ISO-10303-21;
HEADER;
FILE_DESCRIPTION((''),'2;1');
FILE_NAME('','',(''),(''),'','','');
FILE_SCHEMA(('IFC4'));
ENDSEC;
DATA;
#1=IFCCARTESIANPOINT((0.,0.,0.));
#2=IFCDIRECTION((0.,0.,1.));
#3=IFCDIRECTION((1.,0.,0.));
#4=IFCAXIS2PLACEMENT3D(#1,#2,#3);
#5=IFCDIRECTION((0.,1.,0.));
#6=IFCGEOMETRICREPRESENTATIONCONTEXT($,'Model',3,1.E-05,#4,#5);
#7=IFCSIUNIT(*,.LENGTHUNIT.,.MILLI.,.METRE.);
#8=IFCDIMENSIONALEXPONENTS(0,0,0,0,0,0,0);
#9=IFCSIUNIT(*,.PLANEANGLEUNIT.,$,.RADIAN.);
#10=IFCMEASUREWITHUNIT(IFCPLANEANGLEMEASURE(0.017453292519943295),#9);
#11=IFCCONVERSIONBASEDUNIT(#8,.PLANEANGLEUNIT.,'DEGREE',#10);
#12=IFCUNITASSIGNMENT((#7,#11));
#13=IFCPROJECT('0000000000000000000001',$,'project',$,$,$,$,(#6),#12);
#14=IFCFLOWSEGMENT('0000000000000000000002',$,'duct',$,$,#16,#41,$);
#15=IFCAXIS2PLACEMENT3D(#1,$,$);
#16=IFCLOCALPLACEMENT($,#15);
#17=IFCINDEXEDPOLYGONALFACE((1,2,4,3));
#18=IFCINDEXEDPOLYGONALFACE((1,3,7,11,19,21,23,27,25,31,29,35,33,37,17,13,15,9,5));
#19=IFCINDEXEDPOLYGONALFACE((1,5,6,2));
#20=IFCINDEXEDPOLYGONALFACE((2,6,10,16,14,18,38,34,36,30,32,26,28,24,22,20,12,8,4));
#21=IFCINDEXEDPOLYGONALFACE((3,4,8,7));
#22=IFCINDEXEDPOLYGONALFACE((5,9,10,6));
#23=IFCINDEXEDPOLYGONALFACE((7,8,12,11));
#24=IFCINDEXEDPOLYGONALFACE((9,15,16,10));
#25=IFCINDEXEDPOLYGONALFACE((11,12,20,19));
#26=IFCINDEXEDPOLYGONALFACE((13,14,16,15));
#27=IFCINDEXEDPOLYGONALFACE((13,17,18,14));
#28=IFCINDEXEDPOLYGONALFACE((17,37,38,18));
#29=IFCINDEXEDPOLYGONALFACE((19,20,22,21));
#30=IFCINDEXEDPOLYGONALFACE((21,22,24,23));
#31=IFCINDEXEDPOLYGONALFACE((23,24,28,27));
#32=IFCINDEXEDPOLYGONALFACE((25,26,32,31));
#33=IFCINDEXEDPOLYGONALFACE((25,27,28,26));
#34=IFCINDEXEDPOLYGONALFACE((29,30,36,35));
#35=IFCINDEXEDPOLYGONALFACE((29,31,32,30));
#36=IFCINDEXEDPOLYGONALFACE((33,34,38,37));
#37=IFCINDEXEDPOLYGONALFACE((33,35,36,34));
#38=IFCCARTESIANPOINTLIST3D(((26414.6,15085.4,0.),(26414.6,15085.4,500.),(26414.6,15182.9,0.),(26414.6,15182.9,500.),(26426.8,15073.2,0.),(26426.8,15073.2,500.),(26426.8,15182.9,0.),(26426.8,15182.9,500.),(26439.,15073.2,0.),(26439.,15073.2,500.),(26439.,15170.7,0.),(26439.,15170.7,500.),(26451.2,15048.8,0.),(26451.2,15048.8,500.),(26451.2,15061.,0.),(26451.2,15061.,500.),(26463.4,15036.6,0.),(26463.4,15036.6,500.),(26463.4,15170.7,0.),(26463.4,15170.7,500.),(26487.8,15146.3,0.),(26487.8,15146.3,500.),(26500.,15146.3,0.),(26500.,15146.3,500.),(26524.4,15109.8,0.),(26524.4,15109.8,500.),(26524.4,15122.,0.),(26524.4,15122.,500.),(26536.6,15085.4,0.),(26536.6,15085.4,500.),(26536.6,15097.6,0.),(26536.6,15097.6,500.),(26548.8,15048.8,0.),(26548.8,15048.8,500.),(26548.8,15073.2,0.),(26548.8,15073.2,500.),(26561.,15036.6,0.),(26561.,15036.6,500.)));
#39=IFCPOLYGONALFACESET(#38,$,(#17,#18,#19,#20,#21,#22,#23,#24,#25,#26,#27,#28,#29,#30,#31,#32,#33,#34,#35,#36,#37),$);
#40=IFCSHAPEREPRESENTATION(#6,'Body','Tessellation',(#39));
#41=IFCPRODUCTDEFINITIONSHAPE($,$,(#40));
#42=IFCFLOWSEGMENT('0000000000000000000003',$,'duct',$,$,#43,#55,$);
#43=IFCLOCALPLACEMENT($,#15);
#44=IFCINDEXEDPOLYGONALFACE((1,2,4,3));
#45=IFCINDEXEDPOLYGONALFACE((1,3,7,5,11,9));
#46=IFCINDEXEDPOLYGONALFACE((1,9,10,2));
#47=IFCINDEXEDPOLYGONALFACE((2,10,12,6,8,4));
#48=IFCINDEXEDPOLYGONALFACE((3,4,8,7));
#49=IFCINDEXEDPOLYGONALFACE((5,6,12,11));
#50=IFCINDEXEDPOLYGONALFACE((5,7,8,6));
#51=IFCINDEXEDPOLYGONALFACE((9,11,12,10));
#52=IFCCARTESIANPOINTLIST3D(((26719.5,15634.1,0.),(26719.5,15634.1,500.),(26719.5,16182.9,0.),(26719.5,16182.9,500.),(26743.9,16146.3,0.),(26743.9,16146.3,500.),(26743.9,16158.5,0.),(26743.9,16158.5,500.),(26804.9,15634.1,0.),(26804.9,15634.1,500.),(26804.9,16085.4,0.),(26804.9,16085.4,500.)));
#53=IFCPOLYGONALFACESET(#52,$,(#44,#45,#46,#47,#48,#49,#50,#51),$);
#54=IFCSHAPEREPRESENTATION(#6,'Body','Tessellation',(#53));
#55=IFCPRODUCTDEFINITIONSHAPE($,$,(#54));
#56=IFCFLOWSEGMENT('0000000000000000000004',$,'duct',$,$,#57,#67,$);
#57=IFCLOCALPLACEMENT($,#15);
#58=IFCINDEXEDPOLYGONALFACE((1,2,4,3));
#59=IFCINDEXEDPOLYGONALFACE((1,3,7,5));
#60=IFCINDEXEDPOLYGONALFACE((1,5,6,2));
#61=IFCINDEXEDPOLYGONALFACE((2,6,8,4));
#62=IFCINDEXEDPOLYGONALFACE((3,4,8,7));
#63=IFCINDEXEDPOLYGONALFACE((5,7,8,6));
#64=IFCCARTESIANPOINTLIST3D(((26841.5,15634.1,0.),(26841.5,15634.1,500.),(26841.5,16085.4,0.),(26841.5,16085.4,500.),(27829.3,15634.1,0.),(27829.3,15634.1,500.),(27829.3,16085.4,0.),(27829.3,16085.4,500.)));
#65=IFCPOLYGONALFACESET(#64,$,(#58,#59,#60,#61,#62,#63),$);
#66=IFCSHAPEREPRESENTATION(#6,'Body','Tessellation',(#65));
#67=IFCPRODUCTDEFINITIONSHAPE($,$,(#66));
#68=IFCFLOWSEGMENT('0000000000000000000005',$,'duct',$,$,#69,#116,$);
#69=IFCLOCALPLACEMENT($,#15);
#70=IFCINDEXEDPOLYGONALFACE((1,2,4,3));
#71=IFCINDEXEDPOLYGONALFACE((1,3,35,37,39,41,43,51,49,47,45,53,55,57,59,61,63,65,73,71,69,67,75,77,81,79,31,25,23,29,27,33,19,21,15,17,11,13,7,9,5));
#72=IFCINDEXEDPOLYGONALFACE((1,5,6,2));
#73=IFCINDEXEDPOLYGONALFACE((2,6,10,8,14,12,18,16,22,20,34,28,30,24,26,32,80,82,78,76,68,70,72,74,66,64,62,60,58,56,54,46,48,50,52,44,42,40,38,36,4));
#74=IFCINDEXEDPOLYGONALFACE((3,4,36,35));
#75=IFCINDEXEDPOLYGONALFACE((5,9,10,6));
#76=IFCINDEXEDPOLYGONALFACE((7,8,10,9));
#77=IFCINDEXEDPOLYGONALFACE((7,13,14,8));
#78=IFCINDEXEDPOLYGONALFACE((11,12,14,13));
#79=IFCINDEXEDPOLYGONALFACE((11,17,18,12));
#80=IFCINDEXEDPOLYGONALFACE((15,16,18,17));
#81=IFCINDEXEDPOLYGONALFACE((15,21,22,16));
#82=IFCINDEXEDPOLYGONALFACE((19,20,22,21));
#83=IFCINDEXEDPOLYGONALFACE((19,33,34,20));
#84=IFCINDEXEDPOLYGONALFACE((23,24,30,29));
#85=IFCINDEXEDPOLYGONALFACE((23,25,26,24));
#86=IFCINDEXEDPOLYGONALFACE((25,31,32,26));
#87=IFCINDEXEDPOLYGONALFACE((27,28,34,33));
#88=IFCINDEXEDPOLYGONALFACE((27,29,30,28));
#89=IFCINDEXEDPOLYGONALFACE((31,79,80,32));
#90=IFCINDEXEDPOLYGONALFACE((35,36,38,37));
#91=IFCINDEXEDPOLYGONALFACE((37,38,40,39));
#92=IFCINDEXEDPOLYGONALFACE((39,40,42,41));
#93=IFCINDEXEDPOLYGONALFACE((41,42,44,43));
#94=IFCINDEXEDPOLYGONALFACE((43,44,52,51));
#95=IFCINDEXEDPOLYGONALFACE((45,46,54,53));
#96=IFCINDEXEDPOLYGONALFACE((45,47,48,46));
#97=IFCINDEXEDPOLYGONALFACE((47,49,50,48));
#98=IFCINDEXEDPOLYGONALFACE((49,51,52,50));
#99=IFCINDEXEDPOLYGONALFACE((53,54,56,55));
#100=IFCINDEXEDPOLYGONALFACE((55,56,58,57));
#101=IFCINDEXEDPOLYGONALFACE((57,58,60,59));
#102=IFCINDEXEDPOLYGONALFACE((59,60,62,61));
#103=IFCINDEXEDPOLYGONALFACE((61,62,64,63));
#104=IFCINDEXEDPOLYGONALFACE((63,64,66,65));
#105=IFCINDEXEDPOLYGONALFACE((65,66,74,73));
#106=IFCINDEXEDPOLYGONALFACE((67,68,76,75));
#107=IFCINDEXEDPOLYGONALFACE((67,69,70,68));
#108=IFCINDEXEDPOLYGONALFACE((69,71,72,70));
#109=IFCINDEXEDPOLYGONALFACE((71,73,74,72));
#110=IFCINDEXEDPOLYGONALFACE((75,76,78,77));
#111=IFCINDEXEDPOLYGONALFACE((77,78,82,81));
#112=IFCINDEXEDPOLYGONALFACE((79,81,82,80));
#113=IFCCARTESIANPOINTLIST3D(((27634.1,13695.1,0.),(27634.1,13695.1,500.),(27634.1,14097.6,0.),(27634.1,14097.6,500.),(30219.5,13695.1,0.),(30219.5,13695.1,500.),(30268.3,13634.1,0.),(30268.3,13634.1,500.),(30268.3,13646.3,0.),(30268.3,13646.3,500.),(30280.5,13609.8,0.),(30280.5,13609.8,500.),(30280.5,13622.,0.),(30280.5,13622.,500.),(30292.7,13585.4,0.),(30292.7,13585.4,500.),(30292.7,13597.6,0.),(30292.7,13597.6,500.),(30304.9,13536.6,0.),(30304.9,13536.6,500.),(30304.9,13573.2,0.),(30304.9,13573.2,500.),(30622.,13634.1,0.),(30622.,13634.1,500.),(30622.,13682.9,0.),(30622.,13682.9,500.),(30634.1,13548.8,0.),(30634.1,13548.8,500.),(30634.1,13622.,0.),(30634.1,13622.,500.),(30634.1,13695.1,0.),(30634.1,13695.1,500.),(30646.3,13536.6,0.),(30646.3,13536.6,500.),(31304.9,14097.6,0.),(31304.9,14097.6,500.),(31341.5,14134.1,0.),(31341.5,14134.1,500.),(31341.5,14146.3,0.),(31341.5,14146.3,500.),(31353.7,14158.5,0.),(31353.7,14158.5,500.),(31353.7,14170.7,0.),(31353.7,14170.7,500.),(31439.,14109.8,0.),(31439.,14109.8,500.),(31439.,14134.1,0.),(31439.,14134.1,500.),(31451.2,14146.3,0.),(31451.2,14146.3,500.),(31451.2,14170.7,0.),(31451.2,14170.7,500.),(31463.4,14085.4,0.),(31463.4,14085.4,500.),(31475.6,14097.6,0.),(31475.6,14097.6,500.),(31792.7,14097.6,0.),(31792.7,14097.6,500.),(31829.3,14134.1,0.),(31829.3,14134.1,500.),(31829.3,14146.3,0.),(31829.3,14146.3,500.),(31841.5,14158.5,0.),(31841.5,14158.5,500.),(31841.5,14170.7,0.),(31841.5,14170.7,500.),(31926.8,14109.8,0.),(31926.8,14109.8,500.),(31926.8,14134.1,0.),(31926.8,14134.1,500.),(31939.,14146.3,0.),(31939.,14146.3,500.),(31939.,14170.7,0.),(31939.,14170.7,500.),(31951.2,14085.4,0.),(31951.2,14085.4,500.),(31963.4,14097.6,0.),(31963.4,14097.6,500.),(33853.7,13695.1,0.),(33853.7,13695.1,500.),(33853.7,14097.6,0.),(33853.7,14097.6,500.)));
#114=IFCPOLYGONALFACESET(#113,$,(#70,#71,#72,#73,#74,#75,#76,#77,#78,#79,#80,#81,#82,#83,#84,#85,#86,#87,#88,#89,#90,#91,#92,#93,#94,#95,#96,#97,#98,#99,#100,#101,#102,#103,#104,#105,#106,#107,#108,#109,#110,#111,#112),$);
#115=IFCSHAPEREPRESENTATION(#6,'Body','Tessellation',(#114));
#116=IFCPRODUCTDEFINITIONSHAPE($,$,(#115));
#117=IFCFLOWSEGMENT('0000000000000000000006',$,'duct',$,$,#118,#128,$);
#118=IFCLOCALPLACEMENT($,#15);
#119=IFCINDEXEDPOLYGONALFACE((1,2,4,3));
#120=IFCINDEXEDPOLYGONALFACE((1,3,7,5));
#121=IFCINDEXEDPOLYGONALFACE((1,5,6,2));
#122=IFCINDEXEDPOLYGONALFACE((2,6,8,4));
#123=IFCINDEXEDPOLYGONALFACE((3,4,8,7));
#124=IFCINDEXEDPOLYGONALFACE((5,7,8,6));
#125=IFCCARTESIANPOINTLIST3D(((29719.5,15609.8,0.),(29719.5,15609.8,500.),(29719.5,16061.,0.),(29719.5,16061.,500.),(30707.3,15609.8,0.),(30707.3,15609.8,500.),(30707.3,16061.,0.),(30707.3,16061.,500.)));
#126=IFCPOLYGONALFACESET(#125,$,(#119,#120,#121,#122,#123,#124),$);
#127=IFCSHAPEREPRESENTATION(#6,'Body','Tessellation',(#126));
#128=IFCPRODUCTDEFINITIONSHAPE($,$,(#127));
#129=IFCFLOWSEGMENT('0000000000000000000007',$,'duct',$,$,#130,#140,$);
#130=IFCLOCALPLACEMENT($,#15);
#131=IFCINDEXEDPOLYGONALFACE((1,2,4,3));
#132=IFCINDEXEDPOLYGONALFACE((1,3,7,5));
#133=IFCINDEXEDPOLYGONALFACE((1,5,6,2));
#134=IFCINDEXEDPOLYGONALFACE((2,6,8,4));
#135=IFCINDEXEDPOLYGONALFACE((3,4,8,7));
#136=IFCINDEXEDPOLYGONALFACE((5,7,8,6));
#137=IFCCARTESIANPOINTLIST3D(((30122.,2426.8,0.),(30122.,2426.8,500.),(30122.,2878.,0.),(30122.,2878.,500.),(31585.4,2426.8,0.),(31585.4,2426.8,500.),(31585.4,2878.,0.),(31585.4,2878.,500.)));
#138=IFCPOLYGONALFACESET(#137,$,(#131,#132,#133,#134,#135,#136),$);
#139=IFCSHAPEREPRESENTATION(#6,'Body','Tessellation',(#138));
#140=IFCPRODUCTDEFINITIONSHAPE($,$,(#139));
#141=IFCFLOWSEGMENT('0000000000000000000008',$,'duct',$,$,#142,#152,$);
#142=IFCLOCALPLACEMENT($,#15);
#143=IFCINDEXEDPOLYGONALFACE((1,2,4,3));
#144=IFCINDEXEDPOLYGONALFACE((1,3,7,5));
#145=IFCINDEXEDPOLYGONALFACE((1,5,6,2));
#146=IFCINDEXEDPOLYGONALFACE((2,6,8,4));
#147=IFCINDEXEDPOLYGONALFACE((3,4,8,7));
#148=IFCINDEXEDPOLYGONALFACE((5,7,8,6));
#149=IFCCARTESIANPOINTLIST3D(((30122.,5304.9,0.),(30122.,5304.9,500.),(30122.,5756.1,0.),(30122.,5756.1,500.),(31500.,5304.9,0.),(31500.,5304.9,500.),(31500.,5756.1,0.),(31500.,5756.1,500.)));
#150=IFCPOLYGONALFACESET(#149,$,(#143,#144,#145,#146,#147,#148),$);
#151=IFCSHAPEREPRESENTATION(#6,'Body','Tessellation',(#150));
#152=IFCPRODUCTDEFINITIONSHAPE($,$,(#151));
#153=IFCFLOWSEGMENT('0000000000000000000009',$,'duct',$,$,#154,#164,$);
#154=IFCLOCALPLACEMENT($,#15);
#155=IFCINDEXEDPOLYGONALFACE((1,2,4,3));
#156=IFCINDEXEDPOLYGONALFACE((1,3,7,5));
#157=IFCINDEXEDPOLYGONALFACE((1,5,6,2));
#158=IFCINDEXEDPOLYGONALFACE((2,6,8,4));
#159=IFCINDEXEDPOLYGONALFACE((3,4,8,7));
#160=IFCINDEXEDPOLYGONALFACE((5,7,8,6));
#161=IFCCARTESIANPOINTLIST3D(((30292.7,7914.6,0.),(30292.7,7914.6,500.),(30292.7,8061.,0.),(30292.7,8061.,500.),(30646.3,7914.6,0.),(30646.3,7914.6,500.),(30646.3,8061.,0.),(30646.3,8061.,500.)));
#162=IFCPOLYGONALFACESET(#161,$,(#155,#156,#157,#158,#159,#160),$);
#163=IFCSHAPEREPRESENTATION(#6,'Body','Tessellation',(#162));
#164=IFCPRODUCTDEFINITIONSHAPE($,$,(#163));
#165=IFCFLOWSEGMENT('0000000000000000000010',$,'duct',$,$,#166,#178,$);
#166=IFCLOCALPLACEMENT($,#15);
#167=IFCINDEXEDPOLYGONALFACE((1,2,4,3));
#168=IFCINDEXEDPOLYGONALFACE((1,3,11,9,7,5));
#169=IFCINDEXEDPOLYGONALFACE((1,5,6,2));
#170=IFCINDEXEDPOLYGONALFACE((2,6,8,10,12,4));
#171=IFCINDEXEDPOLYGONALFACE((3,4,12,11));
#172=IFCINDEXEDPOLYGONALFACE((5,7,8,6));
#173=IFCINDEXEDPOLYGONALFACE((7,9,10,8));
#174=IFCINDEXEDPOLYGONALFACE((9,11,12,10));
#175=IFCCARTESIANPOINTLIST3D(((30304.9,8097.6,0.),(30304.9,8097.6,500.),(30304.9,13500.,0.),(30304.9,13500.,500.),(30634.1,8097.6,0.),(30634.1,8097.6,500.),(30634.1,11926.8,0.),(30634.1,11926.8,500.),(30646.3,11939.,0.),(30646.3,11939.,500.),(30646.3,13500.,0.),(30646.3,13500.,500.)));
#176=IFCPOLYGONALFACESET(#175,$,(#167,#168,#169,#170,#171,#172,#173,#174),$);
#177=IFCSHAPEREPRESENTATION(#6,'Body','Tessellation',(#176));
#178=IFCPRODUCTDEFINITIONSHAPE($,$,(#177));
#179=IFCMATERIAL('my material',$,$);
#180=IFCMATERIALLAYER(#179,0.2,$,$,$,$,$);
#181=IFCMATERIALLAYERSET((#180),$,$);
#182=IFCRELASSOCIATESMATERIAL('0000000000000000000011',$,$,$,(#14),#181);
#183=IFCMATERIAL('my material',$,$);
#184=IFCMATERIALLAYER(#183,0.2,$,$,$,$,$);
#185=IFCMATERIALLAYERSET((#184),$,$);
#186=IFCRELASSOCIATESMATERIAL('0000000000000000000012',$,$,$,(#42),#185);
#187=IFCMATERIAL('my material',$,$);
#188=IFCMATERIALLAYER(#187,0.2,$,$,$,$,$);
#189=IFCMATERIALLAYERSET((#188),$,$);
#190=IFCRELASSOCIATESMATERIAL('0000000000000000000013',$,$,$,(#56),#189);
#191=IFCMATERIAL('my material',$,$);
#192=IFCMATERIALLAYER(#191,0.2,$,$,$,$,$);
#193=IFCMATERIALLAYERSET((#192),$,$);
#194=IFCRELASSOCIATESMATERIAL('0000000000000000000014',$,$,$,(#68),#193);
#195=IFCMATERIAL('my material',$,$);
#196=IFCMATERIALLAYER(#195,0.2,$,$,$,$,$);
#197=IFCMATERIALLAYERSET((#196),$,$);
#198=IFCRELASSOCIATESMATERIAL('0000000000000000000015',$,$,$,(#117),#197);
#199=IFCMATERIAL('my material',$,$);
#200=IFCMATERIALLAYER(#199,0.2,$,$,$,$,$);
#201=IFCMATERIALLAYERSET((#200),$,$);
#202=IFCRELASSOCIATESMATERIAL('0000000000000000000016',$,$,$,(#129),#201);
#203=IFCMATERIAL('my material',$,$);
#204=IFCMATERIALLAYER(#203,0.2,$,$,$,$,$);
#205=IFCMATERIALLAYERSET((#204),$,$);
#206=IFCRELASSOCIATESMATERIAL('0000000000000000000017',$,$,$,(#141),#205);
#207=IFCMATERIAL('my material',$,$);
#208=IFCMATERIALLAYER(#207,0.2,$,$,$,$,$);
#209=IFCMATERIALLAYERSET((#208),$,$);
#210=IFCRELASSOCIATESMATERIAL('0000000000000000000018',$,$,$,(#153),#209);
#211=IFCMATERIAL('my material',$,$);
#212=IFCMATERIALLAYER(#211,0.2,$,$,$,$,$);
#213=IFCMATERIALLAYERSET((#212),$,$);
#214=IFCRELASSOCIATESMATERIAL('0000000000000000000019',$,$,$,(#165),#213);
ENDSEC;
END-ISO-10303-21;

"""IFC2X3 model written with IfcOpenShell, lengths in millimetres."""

from ifc_helpers import new_model, entity, si_unit, converted_unit, direction, origin_with_axes, place, context, project, polyline, outline, extrude, material, layer, layer_set, layer_usage, element, save


model = new_model("IFC2X3")

# Units and contexts
model_context = context("Model", 3, precision=1e-05, world=origin_with_axes(), true_north=direction((0.0, 1.0, 0.0)))
ifc_project = project(units=[si_unit("LENGTHUNIT", "METRE", prefix="MILLI"), converted_unit("PLANEANGLEUNIT", "DEGREE", entity("IfcPlaneAngleMeasure", 0.017453292519943295), si_unit("PLANEANGLEUNIT", "RADIAN"), dimensions=[0, 0, 0, 0, 0, 0, 0])], contexts=[model_context])

# Flow segments
ifc_material_1 = material(Name="my material")
ifc_layer_1 = layer(ifc_material_1, 0.2)
ifc_layer_set_1 = layer_set([ifc_layer_1])
ifc_layer_usage_1 = layer_usage(ifc_layer_set_1, "AXIS2", "POSITIVE", -0.1)
flow_segment_1_placement = place(None, origin_with_axes())
element("IfcFlowSegment", 1, at=flow_segment_1_placement, material=ifc_layer_usage_1, Name="duct", context=model_context, shape_type="SweptSolid", body=[
    extrude(outline(polyline([(26414.6, 15085.4), (26426.8, 15073.2), (26439.0, 15073.2), (26451.2, 15061.0), (26451.2, 15048.8), (26463.4, 15036.6), (26561.0, 15036.6), (26548.8, 15048.8), (26548.8, 15073.2), (26536.6, 15085.4), (26536.6, 15097.6), (26524.4, 15109.8), (26524.4, 15122.0), (26500.0, 15146.3), (26487.8, 15146.3), (26463.4, 15170.7), (26439.0, 15170.7), (26426.8, 15182.9), (26414.6, 15182.9), (26414.6, 15085.4)])), origin_with_axes(), (0.0, 0.0, 1.0), 500.0),
])
ifc_material_2 = material(Name="my material")
ifc_layer_2 = layer(ifc_material_2, 0.2)
ifc_layer_set_2 = layer_set([ifc_layer_2])
ifc_layer_usage_2 = layer_usage(ifc_layer_set_2, "AXIS2", "POSITIVE", -0.1)
flow_segment_2_placement = place(None, origin_with_axes())
element("IfcFlowSegment", 2, at=flow_segment_2_placement, material=ifc_layer_usage_2, Name="duct", context=model_context, shape_type="SweptSolid", body=[
    extrude(outline(polyline([(26719.5, 15634.1), (26804.9, 15634.1), (26804.9, 16085.4), (26743.9, 16146.3), (26743.9, 16158.5), (26719.5, 16182.9), (26719.5, 15634.1)])), origin_with_axes(), (0.0, 0.0, 1.0), 500.0),
])
ifc_material_3 = material(Name="my material")
ifc_layer_3 = layer(ifc_material_3, 0.2)
ifc_layer_set_3 = layer_set([ifc_layer_3])
ifc_layer_usage_3 = layer_usage(ifc_layer_set_3, "AXIS2", "POSITIVE", -0.1)
flow_segment_3_placement = place(None, origin_with_axes())
element("IfcFlowSegment", 3, at=flow_segment_3_placement, material=ifc_layer_usage_3, Name="duct", context=model_context, shape_type="SweptSolid", body=[
    extrude(outline(polyline([(26841.5, 15634.1), (27829.3, 15634.1), (27829.3, 16085.4), (26841.5, 16085.4), (26841.5, 15634.1)])), origin_with_axes(), (0.0, 0.0, 1.0), 500.0),
])
ifc_material_4 = material(Name="my material")
ifc_layer_4 = layer(ifc_material_4, 0.2)
ifc_layer_set_4 = layer_set([ifc_layer_4])
ifc_layer_usage_4 = layer_usage(ifc_layer_set_4, "AXIS2", "POSITIVE", -0.1)
flow_segment_4_placement = place(None, origin_with_axes())
element("IfcFlowSegment", 4, at=flow_segment_4_placement, material=ifc_layer_usage_4, Name="duct", context=model_context, shape_type="SweptSolid", body=[
    extrude(outline(polyline([(27634.1, 13695.1), (30219.5, 13695.1), (30268.3, 13646.3), (30268.3, 13634.1), (30280.5, 13622.0), (30280.5, 13609.8), (30292.7, 13597.6), (30292.7, 13585.4), (30304.9, 13573.2), (30304.9, 13536.6), (30646.3, 13536.6), (30634.1, 13548.8), (30634.1, 13622.0), (30622.0, 13634.1), (30622.0, 13682.9), (30634.1, 13695.1), (33853.7, 13695.1), (33853.7, 14097.6), (31963.4, 14097.6), (31951.2, 14085.4), (31926.8, 14109.8), (31926.8, 14134.1), (31939.0, 14146.3), (31939.0, 14170.7), (31841.5, 14170.7), (31841.5, 14158.5), (31829.3, 14146.3), (31829.3, 14134.1), (31792.7, 14097.6), (31475.6, 14097.6), (31463.4, 14085.4), (31439.0, 14109.8), (31439.0, 14134.1), (31451.2, 14146.3), (31451.2, 14170.7), (31353.7, 14170.7), (31353.7, 14158.5), (31341.5, 14146.3), (31341.5, 14134.1), (31304.9, 14097.6), (27634.1, 14097.6), (27634.1, 13695.1)])), origin_with_axes(), (0.0, 0.0, 1.0), 500.0),
])
ifc_material_5 = material(Name="my material")
ifc_layer_5 = layer(ifc_material_5, 0.2)
ifc_layer_set_5 = layer_set([ifc_layer_5])
ifc_layer_usage_5 = layer_usage(ifc_layer_set_5, "AXIS2", "POSITIVE", -0.1)
flow_segment_5_placement = place(None, origin_with_axes())
element("IfcFlowSegment", 5, at=flow_segment_5_placement, material=ifc_layer_usage_5, Name="duct", context=model_context, shape_type="SweptSolid", body=[
    extrude(outline(polyline([(29719.5, 15609.8), (30707.3, 15609.8), (30707.3, 16061.0), (29719.5, 16061.0), (29719.5, 15609.8)])), origin_with_axes(), (0.0, 0.0, 1.0), 500.0),
])
ifc_material_6 = material(Name="my material")
ifc_layer_6 = layer(ifc_material_6, 0.2)
ifc_layer_set_6 = layer_set([ifc_layer_6])
ifc_layer_usage_6 = layer_usage(ifc_layer_set_6, "AXIS2", "POSITIVE", -0.1)
flow_segment_6_placement = place(None, origin_with_axes())
element("IfcFlowSegment", 6, at=flow_segment_6_placement, material=ifc_layer_usage_6, Name="duct", context=model_context, shape_type="SweptSolid", body=[
    extrude(outline(polyline([(30122.0, 2426.8), (31585.4, 2426.8), (31585.4, 2878.0), (30122.0, 2878.0), (30122.0, 2426.8)])), origin_with_axes(), (0.0, 0.0, 1.0), 500.0),
])
ifc_material_7 = material(Name="my material")
ifc_layer_7 = layer(ifc_material_7, 0.2)
ifc_layer_set_7 = layer_set([ifc_layer_7])
ifc_layer_usage_7 = layer_usage(ifc_layer_set_7, "AXIS2", "POSITIVE", -0.1)
flow_segment_7_placement = place(None, origin_with_axes())
element("IfcFlowSegment", 7, at=flow_segment_7_placement, material=ifc_layer_usage_7, Name="duct", context=model_context, shape_type="SweptSolid", body=[
    extrude(outline(polyline([(30122.0, 5304.9), (31500.0, 5304.9), (31500.0, 5756.1), (30122.0, 5756.1), (30122.0, 5304.9)])), origin_with_axes(), (0.0, 0.0, 1.0), 500.0),
])
ifc_material_8 = material(Name="my material")
ifc_layer_8 = layer(ifc_material_8, 0.2)
ifc_layer_set_8 = layer_set([ifc_layer_8])
ifc_layer_usage_8 = layer_usage(ifc_layer_set_8, "AXIS2", "POSITIVE", -0.1)
flow_segment_8_placement = place(None, origin_with_axes())
element("IfcFlowSegment", 8, at=flow_segment_8_placement, material=ifc_layer_usage_8, Name="duct", context=model_context, shape_type="SweptSolid", body=[
    extrude(outline(polyline([(30292.7, 7914.6), (30646.3, 7914.6), (30646.3, 8061.0), (30292.7, 8061.0), (30292.7, 7914.6)])), origin_with_axes(), (0.0, 0.0, 1.0), 500.0),
])
ifc_material_9 = material(Name="my material")
ifc_layer_9 = layer(ifc_material_9, 0.2)
ifc_layer_set_9 = layer_set([ifc_layer_9])
ifc_layer_usage_9 = layer_usage(ifc_layer_set_9, "AXIS2", "POSITIVE", -0.1)
flow_segment_9_placement = place(None, origin_with_axes())
element("IfcFlowSegment", 9, at=flow_segment_9_placement, material=ifc_layer_usage_9, Name="duct", context=model_context, shape_type="SweptSolid", body=[
    extrude(outline(polyline([(30304.9, 8097.6), (30634.1, 8097.6), (30634.1, 11926.8), (30646.3, 11939.0), (30646.3, 13500.0), (30304.9, 13500.0), (30304.9, 8097.6)])), origin_with_axes(), (0.0, 0.0, 1.0), 500.0),
])

save(model, "model.ifc")
